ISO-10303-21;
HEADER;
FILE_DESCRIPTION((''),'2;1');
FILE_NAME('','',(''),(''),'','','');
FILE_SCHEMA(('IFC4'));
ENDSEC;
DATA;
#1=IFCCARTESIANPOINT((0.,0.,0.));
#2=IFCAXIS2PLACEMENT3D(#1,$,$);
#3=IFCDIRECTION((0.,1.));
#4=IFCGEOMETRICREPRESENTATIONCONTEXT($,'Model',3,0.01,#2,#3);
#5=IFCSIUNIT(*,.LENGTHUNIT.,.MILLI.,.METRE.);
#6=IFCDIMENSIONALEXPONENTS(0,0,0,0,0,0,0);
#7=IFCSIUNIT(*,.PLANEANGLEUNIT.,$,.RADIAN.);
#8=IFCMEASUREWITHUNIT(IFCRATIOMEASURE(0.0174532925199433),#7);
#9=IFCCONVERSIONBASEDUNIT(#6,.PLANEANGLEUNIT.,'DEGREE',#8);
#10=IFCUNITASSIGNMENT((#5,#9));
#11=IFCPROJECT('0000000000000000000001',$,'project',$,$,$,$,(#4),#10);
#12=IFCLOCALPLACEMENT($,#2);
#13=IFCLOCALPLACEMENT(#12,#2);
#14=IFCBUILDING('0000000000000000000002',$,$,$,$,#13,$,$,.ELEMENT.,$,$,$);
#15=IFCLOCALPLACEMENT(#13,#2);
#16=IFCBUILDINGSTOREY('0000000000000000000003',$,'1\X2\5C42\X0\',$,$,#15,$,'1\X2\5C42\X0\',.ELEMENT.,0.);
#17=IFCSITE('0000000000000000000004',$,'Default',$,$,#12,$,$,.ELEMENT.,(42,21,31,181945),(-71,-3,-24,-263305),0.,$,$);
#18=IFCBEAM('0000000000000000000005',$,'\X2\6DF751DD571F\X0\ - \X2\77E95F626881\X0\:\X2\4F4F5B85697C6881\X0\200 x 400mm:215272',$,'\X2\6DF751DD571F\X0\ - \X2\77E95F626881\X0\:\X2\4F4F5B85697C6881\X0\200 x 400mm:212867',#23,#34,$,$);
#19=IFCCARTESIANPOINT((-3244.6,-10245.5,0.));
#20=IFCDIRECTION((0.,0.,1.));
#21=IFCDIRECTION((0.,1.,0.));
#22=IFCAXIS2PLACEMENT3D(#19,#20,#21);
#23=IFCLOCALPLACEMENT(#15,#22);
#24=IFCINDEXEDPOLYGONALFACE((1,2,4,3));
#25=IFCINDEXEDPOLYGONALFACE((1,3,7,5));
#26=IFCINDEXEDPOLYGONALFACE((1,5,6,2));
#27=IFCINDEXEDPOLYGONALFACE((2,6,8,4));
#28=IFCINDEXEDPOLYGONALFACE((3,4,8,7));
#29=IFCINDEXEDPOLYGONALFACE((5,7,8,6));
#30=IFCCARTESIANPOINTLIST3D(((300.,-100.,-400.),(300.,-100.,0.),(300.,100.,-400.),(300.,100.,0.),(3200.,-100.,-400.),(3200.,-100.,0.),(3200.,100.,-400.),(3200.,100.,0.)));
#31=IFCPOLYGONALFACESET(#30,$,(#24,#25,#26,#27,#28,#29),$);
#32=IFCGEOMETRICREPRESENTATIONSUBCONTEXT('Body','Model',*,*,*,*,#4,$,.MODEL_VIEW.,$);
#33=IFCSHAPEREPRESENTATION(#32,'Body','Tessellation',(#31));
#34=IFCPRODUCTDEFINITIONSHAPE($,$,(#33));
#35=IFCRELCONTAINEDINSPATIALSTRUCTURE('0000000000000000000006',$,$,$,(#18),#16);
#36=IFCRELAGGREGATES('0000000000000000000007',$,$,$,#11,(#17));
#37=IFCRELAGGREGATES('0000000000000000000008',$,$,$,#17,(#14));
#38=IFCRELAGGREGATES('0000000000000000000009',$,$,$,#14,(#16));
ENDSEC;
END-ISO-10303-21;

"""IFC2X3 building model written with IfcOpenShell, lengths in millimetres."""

from ifc_helpers import new_model, entity, si_unit, converted_unit, direction, frame, frame_2d, origin, place, context, subcontext, project, spatial, rectangle, extrude, element, save


model = new_model("IFC2X3")

# Units and contexts
model_context = context("Model", 3, precision=0.01, world=origin(), true_north=direction((0.0, 1.0)))
body_context = subcontext(model_context, "Body", "Model", "MODEL_VIEW")
ifc_project = project(units=[si_unit("LENGTHUNIT", "METRE", prefix="MILLI"), converted_unit("PLANEANGLEUNIT", "DEGREE", entity("IfcRatioMeasure", 0.0174532925199433), si_unit("PLANEANGLEUNIT", "RADIAN"), dimensions=[0, 0, 0, 0, 0, 0, 0])], contexts=[model_context])

# Site, building, storey
site_placement = place(None, origin())
site = spatial("IfcSite", under=ifc_project, at=site_placement, Name="Default", CompositionType="ELEMENT", RefLatitude=(42, 21, 31, 181945), RefLongitude=(-71, -3, -24, -263305), RefElevation=0.0)
building_placement = place(site_placement, origin())
building = spatial("IfcBuilding", under=site, at=building_placement, CompositionType="ELEMENT")
storey_placement = place(building_placement, origin())
storey = spatial("IfcBuildingStorey", under=building, at=storey_placement, Name="1层", LongName="1层", CompositionType="ELEMENT", Elevation=0.0)

# Beam
beam_1_placement = place(storey_placement, frame((-3244.6, -10245.5, 0.0), z_axis=(0.0, 0.0, 1.0), x_axis=(0.0, 1.0, 0.0)))
element("IfcBeam", 1, at=beam_1_placement, inside=storey, Name="混凝土 - 矩形梁:住宅楼梁200 x 400mm:215272", ObjectType="混凝土 - 矩形梁:住宅楼梁200 x 400mm:212867", context=body_context, shape_type="SweptSolid", body=[
    extrude(rectangle(XDim=400.0, YDim=200.0, at=frame_2d((0.0, 0.0), x_axis=(1.0, 0.0))), frame((300.0, 0.0, -200.0), z_axis=(1.0, 0.0, 0.0), x_axis=(0.0, 0.0, -1.0)), (0.0, 0.0, 1.0), 2900.0),
])

save(model, "model.ifc")
